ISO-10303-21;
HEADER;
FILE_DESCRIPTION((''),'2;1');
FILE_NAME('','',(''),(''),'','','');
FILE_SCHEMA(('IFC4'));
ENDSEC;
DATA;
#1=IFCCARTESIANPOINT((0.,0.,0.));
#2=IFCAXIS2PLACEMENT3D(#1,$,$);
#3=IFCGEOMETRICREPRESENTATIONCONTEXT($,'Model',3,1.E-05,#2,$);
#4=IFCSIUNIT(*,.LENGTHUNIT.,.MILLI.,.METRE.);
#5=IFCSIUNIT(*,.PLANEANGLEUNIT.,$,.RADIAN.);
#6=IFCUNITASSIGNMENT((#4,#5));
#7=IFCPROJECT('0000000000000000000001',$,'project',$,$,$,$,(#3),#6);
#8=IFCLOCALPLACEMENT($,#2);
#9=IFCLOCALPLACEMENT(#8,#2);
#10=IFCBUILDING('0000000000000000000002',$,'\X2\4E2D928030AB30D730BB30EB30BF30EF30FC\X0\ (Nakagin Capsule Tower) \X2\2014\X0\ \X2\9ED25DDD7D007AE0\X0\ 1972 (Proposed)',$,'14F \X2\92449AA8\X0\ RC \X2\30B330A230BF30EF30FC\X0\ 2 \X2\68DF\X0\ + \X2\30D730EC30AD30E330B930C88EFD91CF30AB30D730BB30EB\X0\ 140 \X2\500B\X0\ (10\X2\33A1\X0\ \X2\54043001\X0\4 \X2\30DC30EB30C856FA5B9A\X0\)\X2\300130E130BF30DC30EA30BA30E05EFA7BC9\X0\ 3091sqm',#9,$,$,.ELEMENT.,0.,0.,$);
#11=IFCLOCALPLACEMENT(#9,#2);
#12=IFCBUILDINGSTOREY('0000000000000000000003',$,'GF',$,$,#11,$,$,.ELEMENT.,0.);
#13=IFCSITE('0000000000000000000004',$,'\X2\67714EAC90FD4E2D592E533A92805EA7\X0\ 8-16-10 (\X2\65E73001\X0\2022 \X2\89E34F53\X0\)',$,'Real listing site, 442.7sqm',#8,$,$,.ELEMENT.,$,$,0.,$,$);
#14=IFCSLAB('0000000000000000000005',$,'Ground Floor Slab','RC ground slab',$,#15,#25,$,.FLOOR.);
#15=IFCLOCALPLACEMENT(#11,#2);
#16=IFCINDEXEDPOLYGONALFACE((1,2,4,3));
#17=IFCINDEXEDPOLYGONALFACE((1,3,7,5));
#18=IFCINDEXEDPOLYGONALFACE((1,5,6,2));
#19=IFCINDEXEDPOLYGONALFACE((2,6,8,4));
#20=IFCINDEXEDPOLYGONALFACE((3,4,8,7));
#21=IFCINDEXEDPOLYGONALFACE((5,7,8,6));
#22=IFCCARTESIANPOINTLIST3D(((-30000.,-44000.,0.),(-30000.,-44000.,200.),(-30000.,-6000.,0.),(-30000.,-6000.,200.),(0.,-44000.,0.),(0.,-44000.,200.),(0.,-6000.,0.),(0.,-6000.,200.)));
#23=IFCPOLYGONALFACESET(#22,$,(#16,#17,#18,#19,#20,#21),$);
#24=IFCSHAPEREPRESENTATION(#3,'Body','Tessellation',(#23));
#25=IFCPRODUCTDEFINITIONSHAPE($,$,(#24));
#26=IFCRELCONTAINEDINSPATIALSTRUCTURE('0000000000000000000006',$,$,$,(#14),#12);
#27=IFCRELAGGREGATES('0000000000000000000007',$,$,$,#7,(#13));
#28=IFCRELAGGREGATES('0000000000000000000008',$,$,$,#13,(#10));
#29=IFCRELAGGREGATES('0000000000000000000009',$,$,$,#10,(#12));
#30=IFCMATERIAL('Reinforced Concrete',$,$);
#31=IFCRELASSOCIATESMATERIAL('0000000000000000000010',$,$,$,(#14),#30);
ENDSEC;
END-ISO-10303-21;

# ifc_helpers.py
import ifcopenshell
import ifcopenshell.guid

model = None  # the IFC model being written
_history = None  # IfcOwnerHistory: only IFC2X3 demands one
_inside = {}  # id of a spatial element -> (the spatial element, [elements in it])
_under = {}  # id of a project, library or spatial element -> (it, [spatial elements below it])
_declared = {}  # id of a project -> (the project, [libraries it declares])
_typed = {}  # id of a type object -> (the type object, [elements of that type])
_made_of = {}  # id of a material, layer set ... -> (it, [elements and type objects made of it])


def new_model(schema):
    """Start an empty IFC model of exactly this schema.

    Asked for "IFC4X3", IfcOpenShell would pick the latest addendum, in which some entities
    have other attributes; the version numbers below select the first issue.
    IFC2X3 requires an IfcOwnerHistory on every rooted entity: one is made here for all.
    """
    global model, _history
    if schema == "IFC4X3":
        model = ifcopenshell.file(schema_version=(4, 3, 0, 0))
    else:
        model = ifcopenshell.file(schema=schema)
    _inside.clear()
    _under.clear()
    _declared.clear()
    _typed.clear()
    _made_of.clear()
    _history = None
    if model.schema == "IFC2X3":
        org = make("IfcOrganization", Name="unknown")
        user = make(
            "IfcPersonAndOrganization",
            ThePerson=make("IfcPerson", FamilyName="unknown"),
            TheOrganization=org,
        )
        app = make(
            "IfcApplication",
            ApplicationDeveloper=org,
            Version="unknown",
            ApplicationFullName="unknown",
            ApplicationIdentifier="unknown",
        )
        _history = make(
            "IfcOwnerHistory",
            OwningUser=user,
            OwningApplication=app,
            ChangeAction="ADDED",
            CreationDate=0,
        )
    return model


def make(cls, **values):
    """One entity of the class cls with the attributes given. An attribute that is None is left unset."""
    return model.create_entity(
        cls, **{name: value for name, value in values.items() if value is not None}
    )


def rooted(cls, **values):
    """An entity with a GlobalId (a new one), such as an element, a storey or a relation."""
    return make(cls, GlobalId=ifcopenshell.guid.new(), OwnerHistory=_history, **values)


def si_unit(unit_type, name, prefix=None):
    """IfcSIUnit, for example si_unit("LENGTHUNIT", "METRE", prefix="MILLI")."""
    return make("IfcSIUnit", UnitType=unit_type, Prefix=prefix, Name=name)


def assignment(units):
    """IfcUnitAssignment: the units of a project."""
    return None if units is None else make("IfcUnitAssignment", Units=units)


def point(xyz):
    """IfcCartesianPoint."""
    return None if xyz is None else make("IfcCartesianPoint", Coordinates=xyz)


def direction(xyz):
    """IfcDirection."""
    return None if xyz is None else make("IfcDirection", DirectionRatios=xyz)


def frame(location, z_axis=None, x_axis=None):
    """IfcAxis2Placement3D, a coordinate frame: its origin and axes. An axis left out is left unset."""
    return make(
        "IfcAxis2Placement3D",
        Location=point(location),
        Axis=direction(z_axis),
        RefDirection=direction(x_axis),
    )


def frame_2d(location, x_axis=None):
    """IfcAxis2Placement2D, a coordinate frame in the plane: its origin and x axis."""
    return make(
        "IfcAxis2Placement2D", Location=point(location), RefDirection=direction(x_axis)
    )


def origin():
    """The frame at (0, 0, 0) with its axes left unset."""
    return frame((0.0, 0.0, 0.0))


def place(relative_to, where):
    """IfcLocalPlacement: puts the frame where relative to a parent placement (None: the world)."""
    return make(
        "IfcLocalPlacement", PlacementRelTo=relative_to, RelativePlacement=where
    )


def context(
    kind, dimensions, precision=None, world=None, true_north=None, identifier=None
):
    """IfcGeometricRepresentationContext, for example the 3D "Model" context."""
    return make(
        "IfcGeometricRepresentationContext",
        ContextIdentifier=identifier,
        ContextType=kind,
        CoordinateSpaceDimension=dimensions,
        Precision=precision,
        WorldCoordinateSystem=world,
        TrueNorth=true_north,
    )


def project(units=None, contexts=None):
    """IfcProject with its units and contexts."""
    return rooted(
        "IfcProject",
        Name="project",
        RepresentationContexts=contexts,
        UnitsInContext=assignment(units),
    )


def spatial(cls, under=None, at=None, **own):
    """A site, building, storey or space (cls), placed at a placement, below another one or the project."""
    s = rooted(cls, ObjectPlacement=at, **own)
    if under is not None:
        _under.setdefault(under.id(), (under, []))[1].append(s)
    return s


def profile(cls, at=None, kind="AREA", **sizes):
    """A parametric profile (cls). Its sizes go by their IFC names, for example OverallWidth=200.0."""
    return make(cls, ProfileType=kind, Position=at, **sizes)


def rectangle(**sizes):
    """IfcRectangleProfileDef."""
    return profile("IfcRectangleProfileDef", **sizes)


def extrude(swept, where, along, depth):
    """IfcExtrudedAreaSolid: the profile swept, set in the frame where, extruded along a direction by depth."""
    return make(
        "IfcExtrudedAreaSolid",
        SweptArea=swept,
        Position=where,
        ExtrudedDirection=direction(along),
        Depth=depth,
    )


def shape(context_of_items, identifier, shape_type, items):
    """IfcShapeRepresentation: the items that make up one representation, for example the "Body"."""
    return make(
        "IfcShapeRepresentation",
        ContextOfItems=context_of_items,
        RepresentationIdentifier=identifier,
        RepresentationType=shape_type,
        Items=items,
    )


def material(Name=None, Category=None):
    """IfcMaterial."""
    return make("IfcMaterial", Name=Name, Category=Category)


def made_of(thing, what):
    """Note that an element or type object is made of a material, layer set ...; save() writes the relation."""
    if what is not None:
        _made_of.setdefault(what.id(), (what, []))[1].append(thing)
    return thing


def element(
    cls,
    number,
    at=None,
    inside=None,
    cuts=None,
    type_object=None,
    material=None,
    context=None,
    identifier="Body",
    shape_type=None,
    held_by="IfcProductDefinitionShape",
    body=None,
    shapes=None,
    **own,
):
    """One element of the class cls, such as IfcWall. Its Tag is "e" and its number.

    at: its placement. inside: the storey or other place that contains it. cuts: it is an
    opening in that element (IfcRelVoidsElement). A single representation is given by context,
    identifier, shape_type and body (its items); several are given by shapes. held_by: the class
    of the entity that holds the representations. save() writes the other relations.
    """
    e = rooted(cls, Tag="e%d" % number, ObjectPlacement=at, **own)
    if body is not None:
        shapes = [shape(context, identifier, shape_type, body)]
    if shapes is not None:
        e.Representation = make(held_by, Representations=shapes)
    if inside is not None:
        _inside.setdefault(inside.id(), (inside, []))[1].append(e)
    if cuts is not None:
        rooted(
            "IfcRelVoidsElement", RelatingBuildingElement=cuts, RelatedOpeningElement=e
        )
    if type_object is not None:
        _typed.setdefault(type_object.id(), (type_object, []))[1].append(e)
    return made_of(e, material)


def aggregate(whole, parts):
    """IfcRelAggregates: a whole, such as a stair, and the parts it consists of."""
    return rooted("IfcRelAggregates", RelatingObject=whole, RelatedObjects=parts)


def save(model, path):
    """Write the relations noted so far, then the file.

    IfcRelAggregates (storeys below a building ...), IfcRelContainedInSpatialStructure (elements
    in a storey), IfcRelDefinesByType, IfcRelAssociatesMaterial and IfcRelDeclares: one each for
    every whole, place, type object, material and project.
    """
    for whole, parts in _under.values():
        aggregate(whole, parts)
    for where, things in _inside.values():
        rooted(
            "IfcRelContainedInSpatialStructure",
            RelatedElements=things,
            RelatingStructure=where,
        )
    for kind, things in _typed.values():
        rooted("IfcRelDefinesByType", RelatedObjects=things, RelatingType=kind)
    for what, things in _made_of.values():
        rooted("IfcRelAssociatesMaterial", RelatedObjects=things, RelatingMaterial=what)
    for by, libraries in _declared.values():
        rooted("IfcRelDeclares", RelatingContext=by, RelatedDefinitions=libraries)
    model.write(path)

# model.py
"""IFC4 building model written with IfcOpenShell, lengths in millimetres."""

from ifc_helpers import new_model, si_unit, frame, frame_2d, origin, place, context, project, spatial, rectangle, extrude, material, element, save


model = new_model("IFC4")

# Units and contexts
model_context = context("Model", 3, precision=1e-05, world=origin())
ifc_project = project(units=[si_unit("LENGTHUNIT", "METRE", prefix="MILLI"), si_unit("PLANEANGLEUNIT", "RADIAN")], contexts=[model_context])

# Site, building, storey
site_placement = place(None, origin())
site = spatial("IfcSite", under=ifc_project, at=site_placement, Name="東京都中央区銀座 8-16-10 (旧、2022 解体)", ObjectType="Real listing site, 442.7sqm", CompositionType="ELEMENT", RefElevation=0.0)
building_placement = place(site_placement, origin())
building = spatial("IfcBuilding", under=site, at=building_placement, Name="中銀カプセルタワー (Nakagin Capsule Tower) — 黒川紀章 1972 (Proposed)", ObjectType="14F 鉄骨 RC コアタワー 2 棟 + プレキャスト軽量カプセル 140 個 (10㎡ 各、4 ボルト固定)、メタボリズム建築 3091sqm", CompositionType="ELEMENT", ElevationOfRefHeight=0.0, ElevationOfTerrain=0.0)
storey_placement = place(building_placement, origin())
storey = spatial("IfcBuildingStorey", under=building, at=storey_placement, Name="GF", CompositionType="ELEMENT", Elevation=0.0)

# Slab
ifc_material_1 = material(Name="Reinforced Concrete")
slab_placement = place(storey_placement, frame((-15000.0, -22000.0, 0.0)))
element("IfcSlab", 1, at=slab_placement, inside=storey, material=ifc_material_1, Name="Ground Floor Slab", Description="RC ground slab", PredefinedType="FLOOR", context=model_context, shape_type="SweptSolid", body=[
    extrude(rectangle(XDim=30000.0, YDim=38000.0, at=frame_2d((15000.0, 19000.0))), frame((-15000.0, -22000.0, 0.0)), (0.0, 0.0, 1.0), 200.0),
])

save(model, "model.ifc")
